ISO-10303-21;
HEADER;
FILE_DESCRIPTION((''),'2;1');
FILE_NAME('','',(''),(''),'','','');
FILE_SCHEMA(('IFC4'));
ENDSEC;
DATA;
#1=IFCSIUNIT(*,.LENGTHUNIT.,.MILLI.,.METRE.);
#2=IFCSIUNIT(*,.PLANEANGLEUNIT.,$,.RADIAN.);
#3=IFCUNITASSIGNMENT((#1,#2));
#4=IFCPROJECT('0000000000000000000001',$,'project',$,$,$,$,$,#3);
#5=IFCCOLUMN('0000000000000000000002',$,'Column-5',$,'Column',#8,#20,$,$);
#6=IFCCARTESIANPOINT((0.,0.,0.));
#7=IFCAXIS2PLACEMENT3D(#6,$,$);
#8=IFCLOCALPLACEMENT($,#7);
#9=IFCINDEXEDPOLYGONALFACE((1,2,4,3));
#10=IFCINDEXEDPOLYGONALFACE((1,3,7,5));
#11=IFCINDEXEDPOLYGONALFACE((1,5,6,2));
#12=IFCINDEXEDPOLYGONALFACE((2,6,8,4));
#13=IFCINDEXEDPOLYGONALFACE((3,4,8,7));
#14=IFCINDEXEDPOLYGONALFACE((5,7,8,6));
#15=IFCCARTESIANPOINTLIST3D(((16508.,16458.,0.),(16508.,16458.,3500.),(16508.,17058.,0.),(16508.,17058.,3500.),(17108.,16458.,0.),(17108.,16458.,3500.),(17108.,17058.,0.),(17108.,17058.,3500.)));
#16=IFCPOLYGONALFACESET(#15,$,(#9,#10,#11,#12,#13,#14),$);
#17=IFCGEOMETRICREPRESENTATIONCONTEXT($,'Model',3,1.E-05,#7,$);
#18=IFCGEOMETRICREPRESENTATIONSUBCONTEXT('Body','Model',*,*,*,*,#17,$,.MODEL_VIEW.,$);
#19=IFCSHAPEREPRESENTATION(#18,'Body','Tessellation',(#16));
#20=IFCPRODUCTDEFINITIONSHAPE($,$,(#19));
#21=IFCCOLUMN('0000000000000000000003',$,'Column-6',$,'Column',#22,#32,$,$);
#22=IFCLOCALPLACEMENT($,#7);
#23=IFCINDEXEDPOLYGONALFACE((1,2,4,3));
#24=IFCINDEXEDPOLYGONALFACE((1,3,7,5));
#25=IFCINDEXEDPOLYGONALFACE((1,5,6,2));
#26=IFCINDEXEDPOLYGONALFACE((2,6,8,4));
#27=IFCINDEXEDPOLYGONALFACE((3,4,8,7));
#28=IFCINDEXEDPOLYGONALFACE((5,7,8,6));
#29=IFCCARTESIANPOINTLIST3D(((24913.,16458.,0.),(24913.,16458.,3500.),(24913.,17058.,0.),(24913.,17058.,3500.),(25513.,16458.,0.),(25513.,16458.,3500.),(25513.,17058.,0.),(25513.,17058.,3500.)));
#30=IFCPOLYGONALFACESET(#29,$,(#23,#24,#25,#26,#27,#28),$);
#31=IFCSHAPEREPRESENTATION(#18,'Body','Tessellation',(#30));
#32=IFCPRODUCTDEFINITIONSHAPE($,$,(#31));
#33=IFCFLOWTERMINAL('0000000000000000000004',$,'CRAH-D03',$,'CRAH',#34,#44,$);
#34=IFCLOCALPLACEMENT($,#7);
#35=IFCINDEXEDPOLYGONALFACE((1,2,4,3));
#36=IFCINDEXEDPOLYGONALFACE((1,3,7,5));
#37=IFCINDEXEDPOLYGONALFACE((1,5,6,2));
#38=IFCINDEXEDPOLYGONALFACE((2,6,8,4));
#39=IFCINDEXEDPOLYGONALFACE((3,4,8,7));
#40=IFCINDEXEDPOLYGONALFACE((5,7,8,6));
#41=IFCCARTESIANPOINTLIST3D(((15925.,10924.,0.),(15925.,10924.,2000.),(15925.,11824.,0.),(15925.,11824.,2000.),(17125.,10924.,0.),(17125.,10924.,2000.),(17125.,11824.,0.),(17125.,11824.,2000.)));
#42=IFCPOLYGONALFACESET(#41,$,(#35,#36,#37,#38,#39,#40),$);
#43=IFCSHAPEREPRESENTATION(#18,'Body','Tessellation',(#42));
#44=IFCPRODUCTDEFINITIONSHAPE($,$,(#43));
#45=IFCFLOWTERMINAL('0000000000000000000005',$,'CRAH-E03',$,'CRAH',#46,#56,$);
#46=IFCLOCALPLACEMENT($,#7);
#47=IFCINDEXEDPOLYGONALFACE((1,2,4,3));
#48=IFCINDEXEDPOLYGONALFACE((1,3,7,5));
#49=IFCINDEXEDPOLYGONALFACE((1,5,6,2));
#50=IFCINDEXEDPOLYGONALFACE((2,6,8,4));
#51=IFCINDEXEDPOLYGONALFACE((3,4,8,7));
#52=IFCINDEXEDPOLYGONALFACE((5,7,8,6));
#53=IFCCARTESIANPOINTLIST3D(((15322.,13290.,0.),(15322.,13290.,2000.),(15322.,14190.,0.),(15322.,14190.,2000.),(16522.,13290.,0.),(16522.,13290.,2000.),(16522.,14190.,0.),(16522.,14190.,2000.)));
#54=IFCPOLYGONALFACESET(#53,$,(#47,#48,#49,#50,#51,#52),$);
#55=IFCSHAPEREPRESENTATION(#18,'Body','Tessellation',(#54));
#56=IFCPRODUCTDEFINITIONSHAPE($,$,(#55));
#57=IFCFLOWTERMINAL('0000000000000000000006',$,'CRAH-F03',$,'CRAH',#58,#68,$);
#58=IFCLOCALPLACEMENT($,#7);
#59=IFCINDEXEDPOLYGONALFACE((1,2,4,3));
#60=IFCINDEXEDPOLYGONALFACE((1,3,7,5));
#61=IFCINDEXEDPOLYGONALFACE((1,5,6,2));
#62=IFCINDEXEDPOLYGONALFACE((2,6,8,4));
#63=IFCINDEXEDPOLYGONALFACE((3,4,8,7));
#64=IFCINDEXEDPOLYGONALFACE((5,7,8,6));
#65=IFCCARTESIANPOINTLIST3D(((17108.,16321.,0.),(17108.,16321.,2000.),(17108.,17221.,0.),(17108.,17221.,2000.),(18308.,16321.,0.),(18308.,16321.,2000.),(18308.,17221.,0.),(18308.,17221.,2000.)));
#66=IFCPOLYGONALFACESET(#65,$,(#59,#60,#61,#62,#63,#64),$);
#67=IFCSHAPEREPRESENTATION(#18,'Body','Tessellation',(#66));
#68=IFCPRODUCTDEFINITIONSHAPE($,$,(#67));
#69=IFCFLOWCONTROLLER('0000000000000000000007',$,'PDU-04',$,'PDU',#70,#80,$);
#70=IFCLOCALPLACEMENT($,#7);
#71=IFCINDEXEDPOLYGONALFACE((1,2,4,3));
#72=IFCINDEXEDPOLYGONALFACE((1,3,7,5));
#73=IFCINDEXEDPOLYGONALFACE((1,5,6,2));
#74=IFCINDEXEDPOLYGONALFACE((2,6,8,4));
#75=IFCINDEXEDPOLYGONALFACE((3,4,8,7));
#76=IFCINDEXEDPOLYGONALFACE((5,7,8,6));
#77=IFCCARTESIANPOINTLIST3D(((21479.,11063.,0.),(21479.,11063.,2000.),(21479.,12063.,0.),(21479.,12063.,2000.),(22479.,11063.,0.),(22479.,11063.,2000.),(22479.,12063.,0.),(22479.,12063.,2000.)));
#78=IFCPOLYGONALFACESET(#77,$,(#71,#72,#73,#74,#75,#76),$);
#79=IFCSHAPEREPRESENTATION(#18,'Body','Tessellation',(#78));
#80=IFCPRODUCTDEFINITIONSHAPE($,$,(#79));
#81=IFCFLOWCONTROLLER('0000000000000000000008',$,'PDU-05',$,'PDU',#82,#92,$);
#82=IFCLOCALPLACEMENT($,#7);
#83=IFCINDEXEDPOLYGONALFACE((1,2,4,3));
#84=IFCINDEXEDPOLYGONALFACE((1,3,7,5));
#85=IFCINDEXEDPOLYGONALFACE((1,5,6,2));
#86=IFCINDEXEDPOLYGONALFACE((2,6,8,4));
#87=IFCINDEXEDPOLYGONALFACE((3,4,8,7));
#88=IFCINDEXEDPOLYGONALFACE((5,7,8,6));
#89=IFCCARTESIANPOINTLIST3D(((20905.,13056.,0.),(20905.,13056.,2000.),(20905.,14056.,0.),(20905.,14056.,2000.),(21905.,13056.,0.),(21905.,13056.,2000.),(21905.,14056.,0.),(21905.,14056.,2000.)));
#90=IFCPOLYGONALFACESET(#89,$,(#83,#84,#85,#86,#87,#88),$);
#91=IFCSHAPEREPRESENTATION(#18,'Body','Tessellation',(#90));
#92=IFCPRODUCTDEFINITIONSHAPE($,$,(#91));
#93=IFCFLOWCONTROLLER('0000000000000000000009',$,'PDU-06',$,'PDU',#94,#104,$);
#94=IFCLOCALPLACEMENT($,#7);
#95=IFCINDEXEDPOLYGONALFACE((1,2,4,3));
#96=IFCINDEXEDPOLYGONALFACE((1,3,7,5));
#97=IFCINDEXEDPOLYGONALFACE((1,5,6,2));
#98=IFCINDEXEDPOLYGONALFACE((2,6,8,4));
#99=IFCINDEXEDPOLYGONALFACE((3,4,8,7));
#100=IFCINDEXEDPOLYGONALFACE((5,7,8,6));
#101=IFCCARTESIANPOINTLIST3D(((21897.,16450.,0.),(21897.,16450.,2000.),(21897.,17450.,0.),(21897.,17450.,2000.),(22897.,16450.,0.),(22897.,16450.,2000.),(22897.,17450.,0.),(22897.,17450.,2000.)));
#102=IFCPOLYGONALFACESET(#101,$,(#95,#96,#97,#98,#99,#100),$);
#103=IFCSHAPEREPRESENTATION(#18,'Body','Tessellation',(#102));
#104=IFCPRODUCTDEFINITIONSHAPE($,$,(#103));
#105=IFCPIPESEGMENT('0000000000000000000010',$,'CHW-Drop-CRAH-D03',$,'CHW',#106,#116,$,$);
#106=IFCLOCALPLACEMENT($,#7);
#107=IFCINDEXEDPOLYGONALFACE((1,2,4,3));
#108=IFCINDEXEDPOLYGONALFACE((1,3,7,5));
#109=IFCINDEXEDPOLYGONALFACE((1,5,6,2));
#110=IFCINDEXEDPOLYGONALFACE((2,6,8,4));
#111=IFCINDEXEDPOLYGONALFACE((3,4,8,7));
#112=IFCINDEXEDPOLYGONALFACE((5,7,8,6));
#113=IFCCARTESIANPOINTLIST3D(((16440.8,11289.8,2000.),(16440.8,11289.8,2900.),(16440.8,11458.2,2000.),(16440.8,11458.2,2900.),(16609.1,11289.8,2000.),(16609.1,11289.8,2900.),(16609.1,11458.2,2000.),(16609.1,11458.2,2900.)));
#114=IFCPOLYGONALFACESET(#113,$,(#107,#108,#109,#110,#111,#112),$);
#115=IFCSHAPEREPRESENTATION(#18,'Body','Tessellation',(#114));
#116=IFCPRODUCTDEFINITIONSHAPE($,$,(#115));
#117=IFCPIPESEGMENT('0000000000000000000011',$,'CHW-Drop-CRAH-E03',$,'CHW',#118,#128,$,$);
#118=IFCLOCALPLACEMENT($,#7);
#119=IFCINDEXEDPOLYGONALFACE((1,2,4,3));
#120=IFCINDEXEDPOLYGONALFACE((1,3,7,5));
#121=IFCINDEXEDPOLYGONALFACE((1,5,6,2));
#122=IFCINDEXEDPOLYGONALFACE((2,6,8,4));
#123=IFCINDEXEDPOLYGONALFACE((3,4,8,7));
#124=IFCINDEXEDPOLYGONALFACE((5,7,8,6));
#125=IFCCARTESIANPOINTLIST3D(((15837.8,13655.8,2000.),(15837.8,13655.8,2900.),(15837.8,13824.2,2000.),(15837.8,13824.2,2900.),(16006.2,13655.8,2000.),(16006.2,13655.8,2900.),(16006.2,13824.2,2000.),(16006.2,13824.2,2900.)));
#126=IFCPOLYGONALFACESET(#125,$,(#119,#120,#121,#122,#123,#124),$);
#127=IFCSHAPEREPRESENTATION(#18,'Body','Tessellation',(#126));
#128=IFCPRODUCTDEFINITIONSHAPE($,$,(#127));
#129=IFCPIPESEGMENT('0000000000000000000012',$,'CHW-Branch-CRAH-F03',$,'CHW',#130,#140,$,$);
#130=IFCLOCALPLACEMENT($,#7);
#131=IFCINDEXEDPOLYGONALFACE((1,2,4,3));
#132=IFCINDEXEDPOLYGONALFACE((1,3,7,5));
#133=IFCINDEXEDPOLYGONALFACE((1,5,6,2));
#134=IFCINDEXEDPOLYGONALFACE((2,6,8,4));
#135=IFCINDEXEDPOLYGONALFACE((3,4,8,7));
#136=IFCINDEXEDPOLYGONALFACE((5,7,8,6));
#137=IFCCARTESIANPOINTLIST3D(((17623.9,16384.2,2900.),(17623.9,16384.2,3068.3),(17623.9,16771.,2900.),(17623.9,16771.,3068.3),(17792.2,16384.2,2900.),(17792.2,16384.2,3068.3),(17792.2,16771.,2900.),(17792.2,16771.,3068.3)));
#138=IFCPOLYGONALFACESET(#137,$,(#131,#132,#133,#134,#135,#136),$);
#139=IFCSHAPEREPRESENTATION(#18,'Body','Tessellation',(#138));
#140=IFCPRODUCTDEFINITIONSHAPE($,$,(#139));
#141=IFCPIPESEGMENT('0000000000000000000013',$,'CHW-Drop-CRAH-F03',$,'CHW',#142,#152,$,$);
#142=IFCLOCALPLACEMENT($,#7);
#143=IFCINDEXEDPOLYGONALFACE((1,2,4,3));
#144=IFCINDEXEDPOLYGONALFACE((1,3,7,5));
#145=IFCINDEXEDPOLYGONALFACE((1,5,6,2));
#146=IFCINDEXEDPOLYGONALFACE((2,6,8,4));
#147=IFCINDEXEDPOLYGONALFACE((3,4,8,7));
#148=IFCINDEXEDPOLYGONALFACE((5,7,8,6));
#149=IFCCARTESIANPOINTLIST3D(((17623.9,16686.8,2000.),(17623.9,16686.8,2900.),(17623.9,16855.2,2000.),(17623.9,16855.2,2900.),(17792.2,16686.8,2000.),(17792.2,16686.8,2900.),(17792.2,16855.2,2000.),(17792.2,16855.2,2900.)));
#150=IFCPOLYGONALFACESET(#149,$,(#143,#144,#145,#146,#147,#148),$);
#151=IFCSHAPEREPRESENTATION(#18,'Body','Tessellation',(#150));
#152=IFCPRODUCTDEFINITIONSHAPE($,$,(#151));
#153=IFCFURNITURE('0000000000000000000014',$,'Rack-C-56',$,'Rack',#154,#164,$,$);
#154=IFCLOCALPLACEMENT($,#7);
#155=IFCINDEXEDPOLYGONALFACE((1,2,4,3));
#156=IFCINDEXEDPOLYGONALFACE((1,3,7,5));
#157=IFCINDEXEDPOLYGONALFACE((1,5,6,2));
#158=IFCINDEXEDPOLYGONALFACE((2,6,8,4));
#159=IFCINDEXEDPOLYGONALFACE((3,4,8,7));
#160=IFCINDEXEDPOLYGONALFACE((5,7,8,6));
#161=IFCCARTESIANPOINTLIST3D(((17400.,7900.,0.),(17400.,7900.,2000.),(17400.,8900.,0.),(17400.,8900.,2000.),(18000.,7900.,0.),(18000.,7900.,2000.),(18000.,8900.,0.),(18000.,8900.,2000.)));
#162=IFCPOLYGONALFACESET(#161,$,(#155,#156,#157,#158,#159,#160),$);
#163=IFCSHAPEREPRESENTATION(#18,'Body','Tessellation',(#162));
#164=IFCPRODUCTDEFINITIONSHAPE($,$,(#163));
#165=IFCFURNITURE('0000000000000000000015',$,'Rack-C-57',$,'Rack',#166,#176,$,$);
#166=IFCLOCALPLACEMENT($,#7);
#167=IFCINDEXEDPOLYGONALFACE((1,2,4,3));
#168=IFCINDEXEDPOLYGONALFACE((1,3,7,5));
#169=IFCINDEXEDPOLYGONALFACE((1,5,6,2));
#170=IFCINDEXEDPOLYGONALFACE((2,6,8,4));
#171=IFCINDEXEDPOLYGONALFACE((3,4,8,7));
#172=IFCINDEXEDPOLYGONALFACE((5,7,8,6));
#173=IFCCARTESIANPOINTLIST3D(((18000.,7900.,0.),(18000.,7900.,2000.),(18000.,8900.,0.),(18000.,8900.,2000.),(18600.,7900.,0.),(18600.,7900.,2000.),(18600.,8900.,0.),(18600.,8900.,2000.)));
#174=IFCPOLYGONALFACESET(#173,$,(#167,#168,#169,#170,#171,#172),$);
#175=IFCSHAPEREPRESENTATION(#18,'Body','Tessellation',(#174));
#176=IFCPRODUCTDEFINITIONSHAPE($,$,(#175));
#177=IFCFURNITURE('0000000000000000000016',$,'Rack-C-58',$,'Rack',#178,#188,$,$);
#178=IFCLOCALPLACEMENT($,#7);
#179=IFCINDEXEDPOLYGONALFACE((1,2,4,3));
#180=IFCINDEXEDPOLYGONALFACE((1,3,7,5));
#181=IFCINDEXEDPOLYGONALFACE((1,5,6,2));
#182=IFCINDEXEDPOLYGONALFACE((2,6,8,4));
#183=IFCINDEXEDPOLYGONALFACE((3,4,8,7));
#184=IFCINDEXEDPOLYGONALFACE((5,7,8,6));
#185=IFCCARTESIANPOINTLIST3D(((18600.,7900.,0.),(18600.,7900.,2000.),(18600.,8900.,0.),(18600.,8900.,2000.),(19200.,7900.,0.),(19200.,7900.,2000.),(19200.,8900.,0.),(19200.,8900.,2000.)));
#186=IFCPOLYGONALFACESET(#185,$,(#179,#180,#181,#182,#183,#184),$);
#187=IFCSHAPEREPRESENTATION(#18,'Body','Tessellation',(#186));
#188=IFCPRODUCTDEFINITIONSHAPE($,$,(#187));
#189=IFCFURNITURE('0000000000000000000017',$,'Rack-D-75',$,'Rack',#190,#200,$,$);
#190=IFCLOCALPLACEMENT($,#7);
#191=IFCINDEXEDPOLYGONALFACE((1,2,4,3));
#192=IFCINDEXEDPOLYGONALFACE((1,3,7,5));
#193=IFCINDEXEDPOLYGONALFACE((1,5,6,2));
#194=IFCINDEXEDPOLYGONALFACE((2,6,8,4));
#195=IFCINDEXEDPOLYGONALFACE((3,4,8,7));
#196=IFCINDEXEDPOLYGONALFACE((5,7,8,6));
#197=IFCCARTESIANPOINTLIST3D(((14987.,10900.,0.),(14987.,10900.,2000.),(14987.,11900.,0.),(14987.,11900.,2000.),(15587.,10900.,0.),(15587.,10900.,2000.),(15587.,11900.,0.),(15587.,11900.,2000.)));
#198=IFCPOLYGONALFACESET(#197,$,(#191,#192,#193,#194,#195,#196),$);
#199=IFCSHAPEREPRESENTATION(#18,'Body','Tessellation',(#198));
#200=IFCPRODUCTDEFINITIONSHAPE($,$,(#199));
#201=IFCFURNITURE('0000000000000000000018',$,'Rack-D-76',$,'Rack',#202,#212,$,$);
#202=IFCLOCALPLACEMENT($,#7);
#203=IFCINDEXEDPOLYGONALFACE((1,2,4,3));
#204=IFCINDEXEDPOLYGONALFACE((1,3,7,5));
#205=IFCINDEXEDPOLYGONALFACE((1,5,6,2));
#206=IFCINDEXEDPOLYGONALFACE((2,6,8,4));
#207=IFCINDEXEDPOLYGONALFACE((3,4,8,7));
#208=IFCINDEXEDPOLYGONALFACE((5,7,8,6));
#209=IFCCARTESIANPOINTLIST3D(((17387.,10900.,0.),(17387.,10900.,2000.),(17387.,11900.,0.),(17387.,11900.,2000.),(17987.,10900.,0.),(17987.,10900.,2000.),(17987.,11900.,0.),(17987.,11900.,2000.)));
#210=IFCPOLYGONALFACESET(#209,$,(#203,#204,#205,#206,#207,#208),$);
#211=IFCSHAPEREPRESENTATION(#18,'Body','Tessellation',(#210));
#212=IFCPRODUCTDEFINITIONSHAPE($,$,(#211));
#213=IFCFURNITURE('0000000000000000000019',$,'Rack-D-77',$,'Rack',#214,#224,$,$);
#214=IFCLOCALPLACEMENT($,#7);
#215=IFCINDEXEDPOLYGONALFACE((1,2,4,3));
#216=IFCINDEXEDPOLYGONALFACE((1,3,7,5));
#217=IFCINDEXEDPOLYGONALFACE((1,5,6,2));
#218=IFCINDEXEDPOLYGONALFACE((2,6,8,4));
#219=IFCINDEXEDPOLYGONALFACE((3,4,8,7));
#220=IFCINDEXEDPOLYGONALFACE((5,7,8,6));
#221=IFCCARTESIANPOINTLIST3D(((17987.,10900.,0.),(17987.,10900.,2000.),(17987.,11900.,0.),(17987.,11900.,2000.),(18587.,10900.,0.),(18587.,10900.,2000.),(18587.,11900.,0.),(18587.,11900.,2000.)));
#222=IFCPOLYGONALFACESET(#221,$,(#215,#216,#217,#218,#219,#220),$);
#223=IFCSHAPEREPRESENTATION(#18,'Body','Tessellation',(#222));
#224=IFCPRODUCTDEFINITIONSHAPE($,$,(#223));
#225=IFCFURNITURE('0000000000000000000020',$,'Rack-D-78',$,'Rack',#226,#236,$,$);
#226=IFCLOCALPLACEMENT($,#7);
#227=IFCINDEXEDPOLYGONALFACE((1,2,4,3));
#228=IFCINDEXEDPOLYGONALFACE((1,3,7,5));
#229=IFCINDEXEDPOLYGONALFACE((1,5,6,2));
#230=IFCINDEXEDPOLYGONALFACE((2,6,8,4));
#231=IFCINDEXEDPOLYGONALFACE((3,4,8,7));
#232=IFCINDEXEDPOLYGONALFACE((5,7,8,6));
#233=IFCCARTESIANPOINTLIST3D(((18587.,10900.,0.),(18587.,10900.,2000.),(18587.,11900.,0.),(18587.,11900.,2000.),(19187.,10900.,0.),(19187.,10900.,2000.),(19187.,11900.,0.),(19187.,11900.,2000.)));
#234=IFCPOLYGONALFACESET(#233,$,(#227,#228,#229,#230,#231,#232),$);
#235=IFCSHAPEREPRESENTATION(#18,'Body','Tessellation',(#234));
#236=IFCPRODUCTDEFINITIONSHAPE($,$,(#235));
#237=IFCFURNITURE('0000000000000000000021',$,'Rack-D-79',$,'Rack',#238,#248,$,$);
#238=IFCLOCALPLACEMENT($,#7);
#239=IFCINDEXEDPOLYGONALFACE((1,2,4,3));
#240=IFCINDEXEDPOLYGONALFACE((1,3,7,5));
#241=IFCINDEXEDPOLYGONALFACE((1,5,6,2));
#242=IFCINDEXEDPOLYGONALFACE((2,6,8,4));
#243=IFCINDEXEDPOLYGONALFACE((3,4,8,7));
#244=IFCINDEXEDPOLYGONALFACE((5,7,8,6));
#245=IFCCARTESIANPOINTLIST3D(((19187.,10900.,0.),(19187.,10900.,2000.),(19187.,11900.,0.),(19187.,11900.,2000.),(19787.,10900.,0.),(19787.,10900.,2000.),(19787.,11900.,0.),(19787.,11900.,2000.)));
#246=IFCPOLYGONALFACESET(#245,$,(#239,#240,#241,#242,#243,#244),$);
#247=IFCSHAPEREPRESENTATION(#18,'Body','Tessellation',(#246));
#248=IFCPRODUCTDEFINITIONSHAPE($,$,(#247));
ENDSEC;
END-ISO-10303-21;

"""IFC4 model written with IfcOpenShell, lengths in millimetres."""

from ifc_helpers import new_model, si_unit, frame, origin, place, context, subcontext, project, rectangle, extrude, element, save


model = new_model("IFC4")

# Units and contexts
model_context = context("Model", 3, precision=1e-05, world=origin())
body_context = subcontext(model_context, "Body", "Model", "MODEL_VIEW")
ifc_project = project(units=[si_unit("LENGTHUNIT", "METRE", prefix="MILLI"), si_unit("PLANEANGLEUNIT", "RADIAN")])

# Columns
for number, where, name in (
    (1, (16808.0, 16758.0, 0.0), "Column-5"),
    (2, (25213.0, 16758.0, 0.0), "Column-6"),
):
    element("IfcColumn", number, at=place(None, frame(where)), Name=name, ObjectType="Column", context=body_context, shape_type="SweptSolid", body=[
        extrude(rectangle(XDim=600.0, YDim=600.0), None, (0.0, 0.0, 1.0), 3500.0),
    ])

# Flow terminals
for number, where, name in (
    (3, (16525.0, 11374.0, 0.0), "CRAH-D03"),
    (4, (15922.0, 13740.0, 0.0), "CRAH-E03"),
    (5, (17708.0, 16771.0, 0.0), "CRAH-F03"),
):
    element("IfcFlowTerminal", number, at=place(None, frame(where)), Name=name, ObjectType="CRAH", context=body_context, shape_type="SweptSolid", body=[
        extrude(rectangle(XDim=1200.0, YDim=900.0), None, (0.0, 0.0, 1.0), 2000.0),
    ])

# Flow controllers
for number, where, name in (
    (6, (21979.0, 11563.0, 0.0), "PDU-04"),
    (7, (21405.0, 13556.0, 0.0), "PDU-05"),
    (8, (22397.0, 16950.0, 0.0), "PDU-06"),
):
    element("IfcFlowController", number, at=place(None, frame(where)), Name=name, ObjectType="PDU", context=body_context, shape_type="SweptSolid", body=[
        extrude(rectangle(XDim=1000.0, YDim=1000.0), None, (0.0, 0.0, 1.0), 2000.0),
    ])

# Pipe segments
for number, where, name in (
    (9, (16525.0, 11374.0, 2000.0), "CHW-Drop-CRAH-D03"),
    (10, (15922.0, 13740.0, 2000.0), "CHW-Drop-CRAH-E03"),
):
    element("IfcPipeSegment", number, at=place(None, frame(where)), Name=name, ObjectType="CHW", context=body_context, shape_type="SweptSolid", body=[
        extrude(rectangle(XDim=168.3, YDim=168.3), None, (0.0, 0.0, 1.0), 900.0),
    ])
pipe_segment_1_placement = place(None, frame((17708.0, 16577.6, 2900.0)))
element("IfcPipeSegment", 11, at=pipe_segment_1_placement, Name="CHW-Branch-CRAH-F03", ObjectType="CHW", context=body_context, shape_type="SweptSolid", body=[
    extrude(rectangle(XDim=168.3, YDim=386.8), None, (0.0, 0.0, 1.0), 168.3),
])
pipe_segment_2_placement = place(None, frame((17708.0, 16771.0, 2000.0)))
element("IfcPipeSegment", 12, at=pipe_segment_2_placement, Name="CHW-Drop-CRAH-F03", ObjectType="CHW", context=body_context, shape_type="SweptSolid", body=[
    extrude(rectangle(XDim=168.3, YDim=168.3), None, (0.0, 0.0, 1.0), 900.0),
])

# Furniture
for number, where, name in (
    (13, (17700.0, 8400.0, 0.0), "Rack-C-56"),
    (14, (18300.0, 8400.0, 0.0), "Rack-C-57"),
    (15, (18900.0, 8400.0, 0.0), "Rack-C-58"),
    (16, (15287.0, 11400.0, 0.0), "Rack-D-75"),
    (17, (17687.0, 11400.0, 0.0), "Rack-D-76"),
    (18, (18287.0, 11400.0, 0.0), "Rack-D-77"),
    (19, (18887.0, 11400.0, 0.0), "Rack-D-78"),
    (20, (19487.0, 11400.0, 0.0), "Rack-D-79"),
):
    element("IfcFurniture", number, at=place(None, frame(where)), Name=name, ObjectType="Rack", context=body_context, shape_type="SweptSolid", body=[
        extrude(rectangle(XDim=600.0, YDim=1000.0), None, (0.0, 0.0, 1.0), 2000.0),
    ])

save(model, "model.ifc")
